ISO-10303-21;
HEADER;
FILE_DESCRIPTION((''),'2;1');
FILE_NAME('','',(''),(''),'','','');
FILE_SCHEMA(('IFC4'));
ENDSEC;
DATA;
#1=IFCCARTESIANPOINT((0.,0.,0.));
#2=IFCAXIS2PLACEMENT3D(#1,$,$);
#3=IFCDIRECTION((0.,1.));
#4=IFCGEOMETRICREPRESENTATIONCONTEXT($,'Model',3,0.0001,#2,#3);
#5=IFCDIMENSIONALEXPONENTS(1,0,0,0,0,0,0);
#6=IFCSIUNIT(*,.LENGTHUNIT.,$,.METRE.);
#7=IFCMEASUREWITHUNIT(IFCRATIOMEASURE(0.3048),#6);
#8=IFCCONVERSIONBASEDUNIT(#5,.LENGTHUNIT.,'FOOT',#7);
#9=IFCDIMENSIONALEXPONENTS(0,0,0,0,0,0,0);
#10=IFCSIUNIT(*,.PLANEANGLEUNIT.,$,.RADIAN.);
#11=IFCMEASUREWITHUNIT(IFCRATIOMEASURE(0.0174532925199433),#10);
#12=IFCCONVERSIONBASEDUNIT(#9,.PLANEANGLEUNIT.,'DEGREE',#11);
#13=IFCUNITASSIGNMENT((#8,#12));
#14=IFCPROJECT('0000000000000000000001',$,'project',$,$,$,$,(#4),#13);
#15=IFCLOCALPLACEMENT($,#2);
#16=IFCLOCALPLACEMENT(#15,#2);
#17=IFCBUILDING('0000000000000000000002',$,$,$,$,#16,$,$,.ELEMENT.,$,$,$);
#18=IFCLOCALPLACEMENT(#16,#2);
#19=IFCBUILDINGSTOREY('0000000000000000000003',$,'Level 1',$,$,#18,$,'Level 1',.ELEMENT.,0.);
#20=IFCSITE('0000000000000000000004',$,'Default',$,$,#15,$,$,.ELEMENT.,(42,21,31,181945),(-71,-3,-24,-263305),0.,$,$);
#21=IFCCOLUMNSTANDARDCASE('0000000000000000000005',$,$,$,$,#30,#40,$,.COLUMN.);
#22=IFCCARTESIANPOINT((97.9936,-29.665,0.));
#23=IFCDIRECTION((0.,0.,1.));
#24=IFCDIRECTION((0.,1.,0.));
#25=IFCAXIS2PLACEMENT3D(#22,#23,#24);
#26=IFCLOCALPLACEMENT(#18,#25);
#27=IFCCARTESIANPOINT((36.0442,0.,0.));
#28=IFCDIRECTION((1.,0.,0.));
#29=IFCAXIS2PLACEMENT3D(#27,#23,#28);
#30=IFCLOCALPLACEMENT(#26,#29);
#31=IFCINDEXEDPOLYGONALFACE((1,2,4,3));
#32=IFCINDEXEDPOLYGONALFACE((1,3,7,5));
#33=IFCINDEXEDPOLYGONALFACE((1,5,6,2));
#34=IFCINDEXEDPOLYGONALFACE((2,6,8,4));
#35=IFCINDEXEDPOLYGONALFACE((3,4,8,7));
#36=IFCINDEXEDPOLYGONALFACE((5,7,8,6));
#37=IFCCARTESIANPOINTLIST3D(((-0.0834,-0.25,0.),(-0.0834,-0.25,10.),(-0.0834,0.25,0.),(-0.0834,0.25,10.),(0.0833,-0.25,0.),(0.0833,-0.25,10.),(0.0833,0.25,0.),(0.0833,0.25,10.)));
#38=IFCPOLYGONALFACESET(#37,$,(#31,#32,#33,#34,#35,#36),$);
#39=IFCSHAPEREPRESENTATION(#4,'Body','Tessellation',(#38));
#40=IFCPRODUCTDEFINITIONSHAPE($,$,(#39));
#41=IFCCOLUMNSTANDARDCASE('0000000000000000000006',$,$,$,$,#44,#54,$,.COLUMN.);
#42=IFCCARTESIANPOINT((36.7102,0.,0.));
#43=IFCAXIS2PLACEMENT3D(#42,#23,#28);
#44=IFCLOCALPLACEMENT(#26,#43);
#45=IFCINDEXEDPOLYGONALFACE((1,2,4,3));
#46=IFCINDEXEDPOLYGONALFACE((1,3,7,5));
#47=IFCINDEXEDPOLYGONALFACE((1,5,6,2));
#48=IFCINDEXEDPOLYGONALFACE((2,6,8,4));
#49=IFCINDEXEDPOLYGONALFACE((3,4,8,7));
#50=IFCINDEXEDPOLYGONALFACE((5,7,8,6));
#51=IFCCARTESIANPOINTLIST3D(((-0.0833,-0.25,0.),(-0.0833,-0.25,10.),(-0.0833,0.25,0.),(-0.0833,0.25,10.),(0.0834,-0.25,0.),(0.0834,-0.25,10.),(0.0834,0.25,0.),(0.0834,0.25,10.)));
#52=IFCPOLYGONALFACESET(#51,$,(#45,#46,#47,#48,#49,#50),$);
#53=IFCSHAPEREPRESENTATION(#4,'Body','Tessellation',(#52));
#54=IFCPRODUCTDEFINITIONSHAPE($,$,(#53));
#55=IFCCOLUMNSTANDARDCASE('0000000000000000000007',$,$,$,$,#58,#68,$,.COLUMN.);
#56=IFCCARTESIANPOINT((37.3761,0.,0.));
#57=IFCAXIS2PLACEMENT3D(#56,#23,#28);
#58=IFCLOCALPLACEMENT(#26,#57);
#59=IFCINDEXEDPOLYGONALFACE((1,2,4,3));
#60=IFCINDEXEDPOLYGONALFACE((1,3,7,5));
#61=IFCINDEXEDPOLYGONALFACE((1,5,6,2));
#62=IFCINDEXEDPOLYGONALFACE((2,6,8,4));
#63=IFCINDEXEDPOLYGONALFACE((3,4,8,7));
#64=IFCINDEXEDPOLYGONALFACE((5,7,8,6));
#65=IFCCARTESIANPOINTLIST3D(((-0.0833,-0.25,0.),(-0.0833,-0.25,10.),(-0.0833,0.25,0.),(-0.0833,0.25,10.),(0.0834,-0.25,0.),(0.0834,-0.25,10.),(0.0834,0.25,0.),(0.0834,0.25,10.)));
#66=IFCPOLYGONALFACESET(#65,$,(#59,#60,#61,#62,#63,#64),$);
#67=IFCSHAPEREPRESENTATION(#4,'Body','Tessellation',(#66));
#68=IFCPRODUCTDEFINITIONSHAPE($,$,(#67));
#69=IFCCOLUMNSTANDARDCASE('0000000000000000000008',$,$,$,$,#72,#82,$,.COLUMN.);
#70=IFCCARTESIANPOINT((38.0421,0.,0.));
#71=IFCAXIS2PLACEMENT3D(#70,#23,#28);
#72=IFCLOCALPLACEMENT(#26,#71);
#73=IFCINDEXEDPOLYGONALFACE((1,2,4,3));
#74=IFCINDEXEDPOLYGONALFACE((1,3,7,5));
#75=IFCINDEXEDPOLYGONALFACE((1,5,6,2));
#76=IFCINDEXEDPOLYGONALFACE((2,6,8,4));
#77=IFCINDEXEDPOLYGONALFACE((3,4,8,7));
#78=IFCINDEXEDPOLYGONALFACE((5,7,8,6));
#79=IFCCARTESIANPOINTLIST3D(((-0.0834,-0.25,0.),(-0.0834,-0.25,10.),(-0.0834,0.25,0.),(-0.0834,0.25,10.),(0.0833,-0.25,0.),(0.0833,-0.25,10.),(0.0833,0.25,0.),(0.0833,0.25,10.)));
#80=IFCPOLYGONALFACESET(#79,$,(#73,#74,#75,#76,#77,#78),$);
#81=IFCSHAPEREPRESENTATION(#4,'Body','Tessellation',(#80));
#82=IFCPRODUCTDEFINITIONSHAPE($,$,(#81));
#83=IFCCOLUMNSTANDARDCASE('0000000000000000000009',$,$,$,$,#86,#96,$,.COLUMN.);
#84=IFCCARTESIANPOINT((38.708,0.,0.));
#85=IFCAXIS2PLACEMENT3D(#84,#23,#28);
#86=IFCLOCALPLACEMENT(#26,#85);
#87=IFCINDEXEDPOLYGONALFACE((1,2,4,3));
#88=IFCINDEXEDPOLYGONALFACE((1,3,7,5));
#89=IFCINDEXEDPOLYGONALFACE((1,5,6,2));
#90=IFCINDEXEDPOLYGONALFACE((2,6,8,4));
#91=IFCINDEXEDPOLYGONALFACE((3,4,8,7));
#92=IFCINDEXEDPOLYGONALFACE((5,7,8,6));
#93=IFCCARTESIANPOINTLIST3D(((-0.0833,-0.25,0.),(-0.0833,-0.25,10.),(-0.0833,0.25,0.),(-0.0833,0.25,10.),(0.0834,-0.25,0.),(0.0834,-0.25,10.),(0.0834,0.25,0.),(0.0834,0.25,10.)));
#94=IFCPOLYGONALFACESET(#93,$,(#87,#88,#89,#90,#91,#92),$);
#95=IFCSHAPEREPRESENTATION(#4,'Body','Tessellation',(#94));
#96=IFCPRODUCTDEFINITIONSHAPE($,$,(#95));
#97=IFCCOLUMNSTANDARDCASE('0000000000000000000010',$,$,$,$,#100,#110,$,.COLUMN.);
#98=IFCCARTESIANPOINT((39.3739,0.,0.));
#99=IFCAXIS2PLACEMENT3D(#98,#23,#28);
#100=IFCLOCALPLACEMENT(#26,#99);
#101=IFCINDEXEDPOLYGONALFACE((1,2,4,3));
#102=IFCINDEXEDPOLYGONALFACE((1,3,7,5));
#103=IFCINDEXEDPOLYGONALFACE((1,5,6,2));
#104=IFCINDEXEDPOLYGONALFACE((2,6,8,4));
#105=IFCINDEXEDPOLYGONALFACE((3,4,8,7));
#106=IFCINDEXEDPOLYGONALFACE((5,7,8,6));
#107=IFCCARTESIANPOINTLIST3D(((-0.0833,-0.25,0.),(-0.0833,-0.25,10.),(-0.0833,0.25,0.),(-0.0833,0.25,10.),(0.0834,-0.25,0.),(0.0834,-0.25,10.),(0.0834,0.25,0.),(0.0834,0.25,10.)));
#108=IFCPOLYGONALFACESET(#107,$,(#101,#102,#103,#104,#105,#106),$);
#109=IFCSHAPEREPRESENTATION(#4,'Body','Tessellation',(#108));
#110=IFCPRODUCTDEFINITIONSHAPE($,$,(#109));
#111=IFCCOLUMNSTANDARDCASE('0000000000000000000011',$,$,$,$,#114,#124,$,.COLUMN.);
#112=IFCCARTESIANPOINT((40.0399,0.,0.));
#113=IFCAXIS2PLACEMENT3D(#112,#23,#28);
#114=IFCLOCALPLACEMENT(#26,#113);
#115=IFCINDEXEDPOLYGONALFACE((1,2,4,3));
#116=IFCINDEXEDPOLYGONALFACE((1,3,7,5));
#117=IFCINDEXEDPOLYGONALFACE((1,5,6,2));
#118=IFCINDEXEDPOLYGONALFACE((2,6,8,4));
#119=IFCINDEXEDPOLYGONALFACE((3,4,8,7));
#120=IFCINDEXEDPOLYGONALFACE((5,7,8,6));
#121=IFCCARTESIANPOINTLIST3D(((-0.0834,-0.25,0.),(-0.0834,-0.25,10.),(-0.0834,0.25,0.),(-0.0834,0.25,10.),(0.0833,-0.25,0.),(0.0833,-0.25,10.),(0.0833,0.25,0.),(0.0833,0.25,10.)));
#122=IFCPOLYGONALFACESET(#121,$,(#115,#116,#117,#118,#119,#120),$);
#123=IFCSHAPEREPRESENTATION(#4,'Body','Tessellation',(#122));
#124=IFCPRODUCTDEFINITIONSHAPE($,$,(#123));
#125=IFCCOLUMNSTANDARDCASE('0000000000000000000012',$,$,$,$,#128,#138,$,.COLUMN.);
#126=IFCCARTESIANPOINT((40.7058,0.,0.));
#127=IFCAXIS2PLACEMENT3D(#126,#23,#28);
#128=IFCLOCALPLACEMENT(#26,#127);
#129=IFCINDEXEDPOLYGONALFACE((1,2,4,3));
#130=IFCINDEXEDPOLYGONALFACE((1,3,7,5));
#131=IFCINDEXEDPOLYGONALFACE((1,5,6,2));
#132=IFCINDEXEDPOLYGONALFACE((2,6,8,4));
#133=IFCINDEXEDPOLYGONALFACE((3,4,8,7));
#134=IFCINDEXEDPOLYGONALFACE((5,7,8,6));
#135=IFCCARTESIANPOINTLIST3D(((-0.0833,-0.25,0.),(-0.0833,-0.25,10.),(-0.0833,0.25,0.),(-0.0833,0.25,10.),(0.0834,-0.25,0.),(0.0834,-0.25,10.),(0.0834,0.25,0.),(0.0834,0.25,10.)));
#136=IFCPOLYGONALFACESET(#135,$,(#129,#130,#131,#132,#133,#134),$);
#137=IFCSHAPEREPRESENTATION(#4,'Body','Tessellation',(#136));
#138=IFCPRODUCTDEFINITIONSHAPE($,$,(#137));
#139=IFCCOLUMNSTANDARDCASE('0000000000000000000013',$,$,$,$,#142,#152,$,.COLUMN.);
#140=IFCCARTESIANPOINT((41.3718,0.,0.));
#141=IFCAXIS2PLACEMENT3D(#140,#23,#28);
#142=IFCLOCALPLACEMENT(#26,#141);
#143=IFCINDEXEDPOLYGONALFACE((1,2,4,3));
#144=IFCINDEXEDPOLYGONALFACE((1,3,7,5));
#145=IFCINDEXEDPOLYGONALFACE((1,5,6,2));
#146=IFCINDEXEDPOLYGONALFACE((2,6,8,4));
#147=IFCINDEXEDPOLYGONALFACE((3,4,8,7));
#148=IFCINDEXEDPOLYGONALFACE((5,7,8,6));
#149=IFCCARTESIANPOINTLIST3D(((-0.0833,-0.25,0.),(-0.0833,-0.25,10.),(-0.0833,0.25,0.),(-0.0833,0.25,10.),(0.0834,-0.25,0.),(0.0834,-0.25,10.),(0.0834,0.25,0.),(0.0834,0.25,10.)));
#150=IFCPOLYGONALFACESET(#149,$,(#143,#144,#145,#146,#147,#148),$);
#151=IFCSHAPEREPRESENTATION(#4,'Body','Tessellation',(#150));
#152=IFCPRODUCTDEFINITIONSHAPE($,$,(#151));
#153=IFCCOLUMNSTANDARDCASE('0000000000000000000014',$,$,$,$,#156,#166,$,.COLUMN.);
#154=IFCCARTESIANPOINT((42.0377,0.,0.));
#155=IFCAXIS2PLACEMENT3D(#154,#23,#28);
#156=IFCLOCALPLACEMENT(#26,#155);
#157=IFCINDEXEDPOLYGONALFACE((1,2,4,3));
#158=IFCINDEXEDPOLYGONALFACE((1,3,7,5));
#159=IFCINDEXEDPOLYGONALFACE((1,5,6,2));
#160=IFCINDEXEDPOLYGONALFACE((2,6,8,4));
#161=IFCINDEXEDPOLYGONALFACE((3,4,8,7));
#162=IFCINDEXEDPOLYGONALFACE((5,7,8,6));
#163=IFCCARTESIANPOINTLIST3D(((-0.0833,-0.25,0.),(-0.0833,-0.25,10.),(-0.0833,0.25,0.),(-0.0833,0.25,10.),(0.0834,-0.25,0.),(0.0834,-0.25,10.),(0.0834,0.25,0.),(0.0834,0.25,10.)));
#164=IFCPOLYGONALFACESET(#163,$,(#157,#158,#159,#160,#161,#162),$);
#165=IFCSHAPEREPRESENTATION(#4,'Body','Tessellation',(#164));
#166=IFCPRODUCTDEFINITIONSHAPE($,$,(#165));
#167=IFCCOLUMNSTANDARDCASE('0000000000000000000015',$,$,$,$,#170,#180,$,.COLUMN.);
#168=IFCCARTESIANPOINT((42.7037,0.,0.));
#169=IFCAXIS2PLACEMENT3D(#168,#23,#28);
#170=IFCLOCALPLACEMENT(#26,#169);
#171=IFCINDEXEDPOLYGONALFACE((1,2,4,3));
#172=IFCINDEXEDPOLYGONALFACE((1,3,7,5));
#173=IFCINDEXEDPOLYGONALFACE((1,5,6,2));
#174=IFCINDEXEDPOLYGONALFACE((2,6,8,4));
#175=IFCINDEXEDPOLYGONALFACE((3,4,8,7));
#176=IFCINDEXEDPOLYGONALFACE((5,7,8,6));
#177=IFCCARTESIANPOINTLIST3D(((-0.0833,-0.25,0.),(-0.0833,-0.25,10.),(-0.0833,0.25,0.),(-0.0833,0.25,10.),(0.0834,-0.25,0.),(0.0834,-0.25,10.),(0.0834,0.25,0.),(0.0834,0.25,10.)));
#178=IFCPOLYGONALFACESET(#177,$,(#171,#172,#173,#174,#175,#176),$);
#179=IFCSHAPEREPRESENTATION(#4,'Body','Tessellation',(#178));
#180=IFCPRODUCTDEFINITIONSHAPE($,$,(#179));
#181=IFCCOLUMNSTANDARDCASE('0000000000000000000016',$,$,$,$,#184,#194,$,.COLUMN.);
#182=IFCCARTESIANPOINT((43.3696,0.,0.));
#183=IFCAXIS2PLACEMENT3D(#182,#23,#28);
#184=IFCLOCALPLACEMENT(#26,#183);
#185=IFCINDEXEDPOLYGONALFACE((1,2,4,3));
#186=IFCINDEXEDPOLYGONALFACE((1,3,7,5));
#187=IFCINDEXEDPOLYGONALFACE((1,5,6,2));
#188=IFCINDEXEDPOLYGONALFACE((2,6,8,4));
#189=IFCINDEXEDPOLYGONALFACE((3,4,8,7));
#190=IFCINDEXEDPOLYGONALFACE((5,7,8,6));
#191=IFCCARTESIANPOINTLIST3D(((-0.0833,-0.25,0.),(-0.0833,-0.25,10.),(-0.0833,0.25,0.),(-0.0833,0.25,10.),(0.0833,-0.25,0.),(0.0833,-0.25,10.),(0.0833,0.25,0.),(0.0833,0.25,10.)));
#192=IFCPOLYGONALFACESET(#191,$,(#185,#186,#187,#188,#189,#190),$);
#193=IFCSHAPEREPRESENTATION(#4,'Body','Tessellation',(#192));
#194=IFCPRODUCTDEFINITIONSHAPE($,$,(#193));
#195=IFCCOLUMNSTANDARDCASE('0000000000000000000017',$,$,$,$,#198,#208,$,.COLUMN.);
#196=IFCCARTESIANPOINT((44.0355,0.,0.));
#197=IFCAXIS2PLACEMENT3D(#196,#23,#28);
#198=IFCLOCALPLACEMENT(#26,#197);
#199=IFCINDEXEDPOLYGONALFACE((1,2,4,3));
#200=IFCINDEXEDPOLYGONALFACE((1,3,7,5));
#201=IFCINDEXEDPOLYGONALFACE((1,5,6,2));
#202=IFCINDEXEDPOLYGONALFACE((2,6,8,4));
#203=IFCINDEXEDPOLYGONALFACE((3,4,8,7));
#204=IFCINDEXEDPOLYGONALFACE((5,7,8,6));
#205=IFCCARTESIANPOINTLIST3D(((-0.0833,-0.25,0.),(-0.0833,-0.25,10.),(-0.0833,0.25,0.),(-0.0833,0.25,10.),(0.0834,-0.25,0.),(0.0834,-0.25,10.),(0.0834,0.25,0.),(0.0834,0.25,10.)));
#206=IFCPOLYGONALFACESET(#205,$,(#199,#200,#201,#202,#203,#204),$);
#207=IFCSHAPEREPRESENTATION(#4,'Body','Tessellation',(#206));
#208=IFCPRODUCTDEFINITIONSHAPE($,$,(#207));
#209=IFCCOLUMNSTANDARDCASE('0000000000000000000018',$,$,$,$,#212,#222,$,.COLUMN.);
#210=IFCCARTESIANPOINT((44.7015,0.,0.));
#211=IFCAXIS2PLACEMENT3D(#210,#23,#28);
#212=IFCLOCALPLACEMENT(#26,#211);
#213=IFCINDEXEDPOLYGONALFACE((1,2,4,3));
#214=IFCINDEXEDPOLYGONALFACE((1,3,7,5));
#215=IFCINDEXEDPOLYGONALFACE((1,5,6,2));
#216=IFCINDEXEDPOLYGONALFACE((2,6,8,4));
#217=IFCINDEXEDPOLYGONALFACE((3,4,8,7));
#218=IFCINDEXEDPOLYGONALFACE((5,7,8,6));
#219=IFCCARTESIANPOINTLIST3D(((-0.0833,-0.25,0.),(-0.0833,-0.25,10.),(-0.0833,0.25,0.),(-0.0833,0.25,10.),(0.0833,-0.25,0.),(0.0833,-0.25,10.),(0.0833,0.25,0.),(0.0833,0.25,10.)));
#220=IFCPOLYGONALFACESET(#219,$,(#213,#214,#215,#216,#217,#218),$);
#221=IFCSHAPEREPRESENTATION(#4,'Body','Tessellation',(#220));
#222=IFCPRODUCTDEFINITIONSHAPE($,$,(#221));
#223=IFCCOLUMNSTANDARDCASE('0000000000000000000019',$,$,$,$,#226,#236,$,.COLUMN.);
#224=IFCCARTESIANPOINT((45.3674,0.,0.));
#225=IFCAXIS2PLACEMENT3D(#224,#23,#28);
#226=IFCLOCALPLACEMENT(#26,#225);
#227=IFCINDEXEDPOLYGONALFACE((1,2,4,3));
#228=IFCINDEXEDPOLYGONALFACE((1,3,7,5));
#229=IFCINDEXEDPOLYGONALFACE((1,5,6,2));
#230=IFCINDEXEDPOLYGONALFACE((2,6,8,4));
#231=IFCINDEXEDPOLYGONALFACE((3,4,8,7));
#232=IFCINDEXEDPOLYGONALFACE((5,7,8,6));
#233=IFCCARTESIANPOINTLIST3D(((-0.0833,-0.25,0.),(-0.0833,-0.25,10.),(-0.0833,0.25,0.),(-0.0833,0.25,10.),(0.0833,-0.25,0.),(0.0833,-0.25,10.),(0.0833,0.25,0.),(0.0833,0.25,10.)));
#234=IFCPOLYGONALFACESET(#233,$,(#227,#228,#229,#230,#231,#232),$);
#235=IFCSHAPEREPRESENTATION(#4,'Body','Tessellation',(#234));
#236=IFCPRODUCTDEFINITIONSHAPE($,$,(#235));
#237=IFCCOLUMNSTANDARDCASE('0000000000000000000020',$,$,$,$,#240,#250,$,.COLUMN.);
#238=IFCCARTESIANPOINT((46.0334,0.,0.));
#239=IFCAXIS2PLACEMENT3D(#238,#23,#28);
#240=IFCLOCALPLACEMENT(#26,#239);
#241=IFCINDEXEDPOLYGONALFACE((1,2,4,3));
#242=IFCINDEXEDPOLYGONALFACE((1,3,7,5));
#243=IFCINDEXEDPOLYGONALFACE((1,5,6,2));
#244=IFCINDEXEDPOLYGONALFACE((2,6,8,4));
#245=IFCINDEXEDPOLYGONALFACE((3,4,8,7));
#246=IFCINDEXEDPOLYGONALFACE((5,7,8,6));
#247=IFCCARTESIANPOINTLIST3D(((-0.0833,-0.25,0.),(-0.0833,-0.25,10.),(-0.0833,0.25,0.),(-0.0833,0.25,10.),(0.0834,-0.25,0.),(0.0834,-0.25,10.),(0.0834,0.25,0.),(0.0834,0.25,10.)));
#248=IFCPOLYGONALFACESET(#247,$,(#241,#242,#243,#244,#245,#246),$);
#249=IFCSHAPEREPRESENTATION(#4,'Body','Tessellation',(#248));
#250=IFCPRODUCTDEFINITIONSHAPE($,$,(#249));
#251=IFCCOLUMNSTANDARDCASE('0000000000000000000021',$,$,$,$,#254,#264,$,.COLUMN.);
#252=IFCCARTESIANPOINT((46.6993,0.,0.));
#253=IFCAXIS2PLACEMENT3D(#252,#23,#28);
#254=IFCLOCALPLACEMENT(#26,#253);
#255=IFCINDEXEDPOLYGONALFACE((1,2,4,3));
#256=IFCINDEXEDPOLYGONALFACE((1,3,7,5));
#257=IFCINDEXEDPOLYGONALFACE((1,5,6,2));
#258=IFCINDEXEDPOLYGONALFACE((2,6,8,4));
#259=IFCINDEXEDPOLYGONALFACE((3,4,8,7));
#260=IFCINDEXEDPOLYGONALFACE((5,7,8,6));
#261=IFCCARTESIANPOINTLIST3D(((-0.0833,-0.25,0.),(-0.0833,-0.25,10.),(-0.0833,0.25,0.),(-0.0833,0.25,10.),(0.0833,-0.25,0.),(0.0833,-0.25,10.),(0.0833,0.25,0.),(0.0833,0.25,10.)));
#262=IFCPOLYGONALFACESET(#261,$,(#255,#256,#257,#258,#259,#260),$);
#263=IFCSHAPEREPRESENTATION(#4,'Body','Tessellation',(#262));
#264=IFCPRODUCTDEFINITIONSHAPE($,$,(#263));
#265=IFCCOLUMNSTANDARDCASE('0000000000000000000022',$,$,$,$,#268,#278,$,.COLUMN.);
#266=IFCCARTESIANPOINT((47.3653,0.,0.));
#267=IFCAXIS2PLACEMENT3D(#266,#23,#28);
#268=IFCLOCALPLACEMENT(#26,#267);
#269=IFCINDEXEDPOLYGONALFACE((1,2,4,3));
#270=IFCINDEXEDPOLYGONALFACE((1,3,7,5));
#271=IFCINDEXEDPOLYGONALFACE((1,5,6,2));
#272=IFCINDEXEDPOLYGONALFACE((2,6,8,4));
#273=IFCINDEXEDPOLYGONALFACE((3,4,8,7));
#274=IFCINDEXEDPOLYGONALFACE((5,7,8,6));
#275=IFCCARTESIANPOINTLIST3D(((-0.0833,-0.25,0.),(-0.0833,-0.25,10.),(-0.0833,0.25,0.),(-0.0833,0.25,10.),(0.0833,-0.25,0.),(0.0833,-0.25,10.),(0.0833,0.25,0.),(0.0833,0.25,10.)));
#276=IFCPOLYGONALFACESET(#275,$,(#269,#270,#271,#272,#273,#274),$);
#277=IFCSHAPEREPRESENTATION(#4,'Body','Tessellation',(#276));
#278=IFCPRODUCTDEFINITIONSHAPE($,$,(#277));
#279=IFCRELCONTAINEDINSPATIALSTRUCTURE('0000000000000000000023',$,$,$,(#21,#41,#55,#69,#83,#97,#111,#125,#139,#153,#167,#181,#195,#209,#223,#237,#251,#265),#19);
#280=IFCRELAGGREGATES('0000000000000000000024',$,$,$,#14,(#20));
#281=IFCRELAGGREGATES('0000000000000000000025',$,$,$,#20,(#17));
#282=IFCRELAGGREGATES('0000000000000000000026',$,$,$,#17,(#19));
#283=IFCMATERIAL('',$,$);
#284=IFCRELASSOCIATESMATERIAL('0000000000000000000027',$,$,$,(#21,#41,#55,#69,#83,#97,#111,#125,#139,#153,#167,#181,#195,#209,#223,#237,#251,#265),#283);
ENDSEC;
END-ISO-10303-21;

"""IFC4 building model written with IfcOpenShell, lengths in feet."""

from ifc_helpers import new_model, entity, si_unit, converted_unit, direction, frame, origin, place, context, project, spatial, rectangle, extrude, material, element, save


model = new_model("IFC4")

# Units and contexts
model_context = context("Model", 3, precision=0.0001, world=origin(), true_north=direction((0.0, 1.0)))
ifc_project = project(units=[converted_unit("LENGTHUNIT", "FOOT", entity("IfcRatioMeasure", 0.3048), si_unit("LENGTHUNIT", "METRE"), dimensions=[1, 0, 0, 0, 0, 0, 0]), converted_unit("PLANEANGLEUNIT", "DEGREE", entity("IfcRatioMeasure", 0.0174532925199433), si_unit("PLANEANGLEUNIT", "RADIAN"), dimensions=[0, 0, 0, 0, 0, 0, 0])], contexts=[model_context])

# Site, building, storey
site_placement = place(None, origin())
site = spatial("IfcSite", under=ifc_project, at=site_placement, Name="Default", CompositionType="ELEMENT", RefLatitude=(42, 21, 31, 181945), RefLongitude=(-71, -3, -24, -263305), RefElevation=0.0)
building_placement = place(site_placement, origin())
building = spatial("IfcBuilding", under=site, at=building_placement, CompositionType="ELEMENT")
storey_placement = place(building_placement, origin())
storey = spatial("IfcBuildingStorey", under=building, at=storey_placement, Name="Level 1", LongName="Level 1", CompositionType="ELEMENT", Elevation=0.0)

# Columns
ifc_material_1 = material(Name="")
placement = place(storey_placement, frame((97.9936, -29.665, 0.0), z_axis=(0.0, 0.0, 1.0), x_axis=(0.0, 1.0, 0.0)))
for number, where, z_axis, x_axis in (
    (1, (36.0442, 0.0, 0.0), (0.0, 0.0, 1.0), (1.0, 0.0, 0.0)),
    (2, (36.7102, 0.0, 0.0), (0.0, 0.0, 1.0), (1.0, 0.0, 0.0)),
    (3, (37.3761, 0.0, 0.0), (0.0, 0.0, 1.0), (1.0, 0.0, 0.0)),
    (4, (38.0421, 0.0, 0.0), (0.0, 0.0, 1.0), (1.0, 0.0, 0.0)),
    (5, (38.708, 0.0, 0.0), (0.0, 0.0, 1.0), (1.0, 0.0, 0.0)),
    (6, (39.3739, 0.0, 0.0), (0.0, 0.0, 1.0), (1.0, 0.0, 0.0)),
    (7, (40.0399, 0.0, 0.0), (0.0, 0.0, 1.0), (1.0, 0.0, 0.0)),
    (8, (40.7058, 0.0, 0.0), (0.0, 0.0, 1.0), (1.0, 0.0, 0.0)),
    (9, (41.3718, 0.0, 0.0), (0.0, 0.0, 1.0), (1.0, 0.0, 0.0)),
    (10, (42.0377, 0.0, 0.0), (0.0, 0.0, 1.0), (1.0, 0.0, 0.0)),
    (11, (42.7037, 0.0, 0.0), (0.0, 0.0, 1.0), (1.0, 0.0, 0.0)),
    (12, (43.3696, 0.0, 0.0), (0.0, 0.0, 1.0), (1.0, 0.0, 0.0)),
    (13, (44.0355, 0.0, 0.0), (0.0, 0.0, 1.0), (1.0, 0.0, 0.0)),
    (14, (44.7015, 0.0, 0.0), (0.0, 0.0, 1.0), (1.0, 0.0, 0.0)),
    (15, (45.3674, 0.0, 0.0), (0.0, 0.0, 1.0), (1.0, 0.0, 0.0)),
    (16, (46.0334, 0.0, 0.0), (0.0, 0.0, 1.0), (1.0, 0.0, 0.0)),
    (17, (46.6993, 0.0, 0.0), (0.0, 0.0, 1.0), (1.0, 0.0, 0.0)),
    (18, (47.3653, 0.0, 0.0), (0.0, 0.0, 1.0), (1.0, 0.0, 0.0)),
):
    element("IfcColumnStandardCase", number, at=place(placement, frame(where, z_axis=z_axis, x_axis=x_axis)), inside=storey, material=ifc_material_1, PredefinedType="COLUMN", context=model_context, shape_type="SweptSolid", body=[
        extrude(rectangle(XDim=0.1667, YDim=0.5), origin(), (0.0, 0.0, 1.0), 10.0),
    ])

save(model, "model.ifc")
